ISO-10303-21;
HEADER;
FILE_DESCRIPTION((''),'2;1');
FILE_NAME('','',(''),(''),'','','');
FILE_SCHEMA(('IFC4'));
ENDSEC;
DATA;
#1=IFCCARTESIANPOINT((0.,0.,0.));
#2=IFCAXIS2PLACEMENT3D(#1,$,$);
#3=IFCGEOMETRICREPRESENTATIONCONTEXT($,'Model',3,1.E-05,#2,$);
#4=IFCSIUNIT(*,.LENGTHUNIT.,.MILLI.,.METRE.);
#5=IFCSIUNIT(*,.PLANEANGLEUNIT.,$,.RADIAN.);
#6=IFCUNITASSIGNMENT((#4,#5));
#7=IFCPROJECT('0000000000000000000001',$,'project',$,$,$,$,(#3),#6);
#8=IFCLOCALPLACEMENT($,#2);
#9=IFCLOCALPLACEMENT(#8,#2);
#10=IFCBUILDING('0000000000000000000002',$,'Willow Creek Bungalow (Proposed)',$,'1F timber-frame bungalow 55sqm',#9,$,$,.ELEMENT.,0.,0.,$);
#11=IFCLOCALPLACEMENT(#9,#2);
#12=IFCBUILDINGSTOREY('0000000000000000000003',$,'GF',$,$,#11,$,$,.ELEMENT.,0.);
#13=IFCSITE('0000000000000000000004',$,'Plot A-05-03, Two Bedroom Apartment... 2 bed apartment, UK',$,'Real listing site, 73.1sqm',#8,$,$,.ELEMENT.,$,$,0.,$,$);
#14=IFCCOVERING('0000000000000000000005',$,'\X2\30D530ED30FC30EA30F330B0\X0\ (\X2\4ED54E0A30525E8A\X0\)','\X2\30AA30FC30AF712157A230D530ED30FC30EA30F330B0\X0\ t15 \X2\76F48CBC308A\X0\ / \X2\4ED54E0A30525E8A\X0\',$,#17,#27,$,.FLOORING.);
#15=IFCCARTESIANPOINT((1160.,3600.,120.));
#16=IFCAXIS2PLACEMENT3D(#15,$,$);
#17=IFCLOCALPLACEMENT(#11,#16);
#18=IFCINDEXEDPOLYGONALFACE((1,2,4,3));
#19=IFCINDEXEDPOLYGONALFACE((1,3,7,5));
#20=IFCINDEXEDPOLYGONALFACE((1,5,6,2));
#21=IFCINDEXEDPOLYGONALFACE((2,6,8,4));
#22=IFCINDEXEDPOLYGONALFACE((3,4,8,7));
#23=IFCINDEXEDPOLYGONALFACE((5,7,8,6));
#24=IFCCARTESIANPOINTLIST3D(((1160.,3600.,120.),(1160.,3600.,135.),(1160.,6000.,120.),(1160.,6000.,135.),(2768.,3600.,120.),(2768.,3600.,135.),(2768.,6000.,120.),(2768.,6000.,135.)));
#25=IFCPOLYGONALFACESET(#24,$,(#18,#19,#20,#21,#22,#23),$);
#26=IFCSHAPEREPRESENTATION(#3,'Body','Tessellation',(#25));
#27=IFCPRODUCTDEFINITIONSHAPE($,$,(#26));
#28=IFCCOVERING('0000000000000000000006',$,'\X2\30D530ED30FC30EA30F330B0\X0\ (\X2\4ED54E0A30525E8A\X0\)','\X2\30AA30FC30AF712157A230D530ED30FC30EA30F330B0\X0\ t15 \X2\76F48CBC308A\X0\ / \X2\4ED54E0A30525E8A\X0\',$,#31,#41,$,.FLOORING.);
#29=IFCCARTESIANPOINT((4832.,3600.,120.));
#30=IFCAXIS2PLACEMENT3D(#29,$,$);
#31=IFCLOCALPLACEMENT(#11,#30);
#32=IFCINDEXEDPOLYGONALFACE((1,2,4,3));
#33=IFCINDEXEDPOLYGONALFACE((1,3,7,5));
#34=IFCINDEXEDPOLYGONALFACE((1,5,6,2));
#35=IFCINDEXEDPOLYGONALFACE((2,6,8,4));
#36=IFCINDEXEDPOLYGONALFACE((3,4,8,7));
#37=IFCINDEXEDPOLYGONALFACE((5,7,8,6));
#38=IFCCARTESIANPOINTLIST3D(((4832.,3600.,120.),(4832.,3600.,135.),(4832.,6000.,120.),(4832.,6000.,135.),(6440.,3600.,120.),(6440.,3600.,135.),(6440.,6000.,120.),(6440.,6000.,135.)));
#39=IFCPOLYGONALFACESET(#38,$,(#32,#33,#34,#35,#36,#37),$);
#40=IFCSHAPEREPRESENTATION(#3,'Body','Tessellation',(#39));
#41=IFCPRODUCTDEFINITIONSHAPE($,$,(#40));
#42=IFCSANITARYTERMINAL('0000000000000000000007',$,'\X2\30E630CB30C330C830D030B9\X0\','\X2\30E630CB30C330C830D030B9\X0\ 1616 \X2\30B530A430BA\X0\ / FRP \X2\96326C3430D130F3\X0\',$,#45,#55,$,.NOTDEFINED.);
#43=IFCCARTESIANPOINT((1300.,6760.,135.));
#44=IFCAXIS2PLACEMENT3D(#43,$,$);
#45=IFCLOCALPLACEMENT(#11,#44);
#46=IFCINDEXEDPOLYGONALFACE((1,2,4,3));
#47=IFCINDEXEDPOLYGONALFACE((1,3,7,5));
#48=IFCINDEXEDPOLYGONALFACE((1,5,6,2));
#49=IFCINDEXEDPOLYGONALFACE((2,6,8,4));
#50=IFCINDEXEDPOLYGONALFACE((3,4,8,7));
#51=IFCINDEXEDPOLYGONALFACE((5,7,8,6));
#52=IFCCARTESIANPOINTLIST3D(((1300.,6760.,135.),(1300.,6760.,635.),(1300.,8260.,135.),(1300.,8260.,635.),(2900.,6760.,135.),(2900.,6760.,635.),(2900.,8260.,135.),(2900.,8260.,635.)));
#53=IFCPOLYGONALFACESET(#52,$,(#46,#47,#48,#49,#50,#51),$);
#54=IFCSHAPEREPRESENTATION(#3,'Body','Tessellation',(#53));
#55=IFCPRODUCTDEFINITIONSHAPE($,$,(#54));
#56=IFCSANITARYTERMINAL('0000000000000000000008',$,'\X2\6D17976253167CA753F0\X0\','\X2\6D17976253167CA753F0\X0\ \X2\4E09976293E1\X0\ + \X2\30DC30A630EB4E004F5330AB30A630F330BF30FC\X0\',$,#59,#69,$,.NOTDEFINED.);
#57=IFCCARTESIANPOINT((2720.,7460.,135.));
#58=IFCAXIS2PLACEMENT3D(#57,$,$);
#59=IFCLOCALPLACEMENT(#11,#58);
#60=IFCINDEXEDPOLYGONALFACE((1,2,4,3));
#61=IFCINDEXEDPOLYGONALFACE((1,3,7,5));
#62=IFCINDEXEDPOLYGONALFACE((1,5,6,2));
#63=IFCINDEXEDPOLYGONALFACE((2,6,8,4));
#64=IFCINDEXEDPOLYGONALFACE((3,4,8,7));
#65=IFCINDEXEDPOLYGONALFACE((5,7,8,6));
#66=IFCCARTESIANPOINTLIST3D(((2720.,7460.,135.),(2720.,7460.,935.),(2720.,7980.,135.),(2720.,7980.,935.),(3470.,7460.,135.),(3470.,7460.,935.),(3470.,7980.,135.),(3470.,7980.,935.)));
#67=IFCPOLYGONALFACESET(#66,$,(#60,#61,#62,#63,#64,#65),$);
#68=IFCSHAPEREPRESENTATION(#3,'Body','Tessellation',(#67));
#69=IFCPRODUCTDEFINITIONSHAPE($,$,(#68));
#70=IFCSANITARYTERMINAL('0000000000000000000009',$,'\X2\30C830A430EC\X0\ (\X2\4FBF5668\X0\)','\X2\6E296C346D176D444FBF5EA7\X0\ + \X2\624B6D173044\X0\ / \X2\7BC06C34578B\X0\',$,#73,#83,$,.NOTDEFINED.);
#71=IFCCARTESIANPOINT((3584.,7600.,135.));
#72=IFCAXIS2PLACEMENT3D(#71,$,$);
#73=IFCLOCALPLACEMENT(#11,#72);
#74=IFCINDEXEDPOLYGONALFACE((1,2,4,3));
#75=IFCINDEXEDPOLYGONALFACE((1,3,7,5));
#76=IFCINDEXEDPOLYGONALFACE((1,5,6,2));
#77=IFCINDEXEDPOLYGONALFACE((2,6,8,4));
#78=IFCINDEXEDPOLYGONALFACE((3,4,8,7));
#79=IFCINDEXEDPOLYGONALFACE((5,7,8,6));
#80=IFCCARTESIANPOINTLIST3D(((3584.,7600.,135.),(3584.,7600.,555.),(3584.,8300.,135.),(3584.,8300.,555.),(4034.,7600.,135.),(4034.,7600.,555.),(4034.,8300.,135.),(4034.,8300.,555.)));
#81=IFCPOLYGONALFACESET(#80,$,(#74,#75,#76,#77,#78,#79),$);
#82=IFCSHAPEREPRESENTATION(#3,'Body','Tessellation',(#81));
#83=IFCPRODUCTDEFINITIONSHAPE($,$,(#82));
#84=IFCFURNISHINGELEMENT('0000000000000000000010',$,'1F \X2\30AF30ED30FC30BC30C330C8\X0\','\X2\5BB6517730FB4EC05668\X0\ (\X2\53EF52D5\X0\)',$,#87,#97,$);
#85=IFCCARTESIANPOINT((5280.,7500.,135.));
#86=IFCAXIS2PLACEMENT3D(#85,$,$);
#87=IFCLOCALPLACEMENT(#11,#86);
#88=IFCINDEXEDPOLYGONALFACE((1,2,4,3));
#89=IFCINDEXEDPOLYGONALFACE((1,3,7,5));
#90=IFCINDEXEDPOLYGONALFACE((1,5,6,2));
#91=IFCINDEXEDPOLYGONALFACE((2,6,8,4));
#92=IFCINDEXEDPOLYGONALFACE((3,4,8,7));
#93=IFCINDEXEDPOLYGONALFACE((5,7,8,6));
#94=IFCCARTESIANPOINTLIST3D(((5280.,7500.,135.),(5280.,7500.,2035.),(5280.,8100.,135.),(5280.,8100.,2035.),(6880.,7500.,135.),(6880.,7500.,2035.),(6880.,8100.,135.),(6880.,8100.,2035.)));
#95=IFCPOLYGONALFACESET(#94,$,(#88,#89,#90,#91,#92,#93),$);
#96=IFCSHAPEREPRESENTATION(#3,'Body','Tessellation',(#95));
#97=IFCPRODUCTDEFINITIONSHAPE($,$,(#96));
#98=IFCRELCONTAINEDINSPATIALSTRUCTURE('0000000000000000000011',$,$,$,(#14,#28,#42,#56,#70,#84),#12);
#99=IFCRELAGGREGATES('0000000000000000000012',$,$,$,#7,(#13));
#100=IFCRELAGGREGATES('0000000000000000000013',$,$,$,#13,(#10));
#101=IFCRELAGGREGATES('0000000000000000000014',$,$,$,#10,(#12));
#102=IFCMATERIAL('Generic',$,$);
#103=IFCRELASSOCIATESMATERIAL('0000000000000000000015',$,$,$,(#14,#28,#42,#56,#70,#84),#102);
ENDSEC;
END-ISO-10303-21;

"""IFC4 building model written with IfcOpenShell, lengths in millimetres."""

from ifc_helpers import new_model, si_unit, frame, frame_2d, origin, place, context, project, spatial, rectangle, extrude, material, element, save


model = new_model("IFC4")

# Units and contexts
model_context = context("Model", 3, precision=1e-05, world=origin())
ifc_project = project(units=[si_unit("LENGTHUNIT", "METRE", prefix="MILLI"), si_unit("PLANEANGLEUNIT", "RADIAN")], contexts=[model_context])

# Site, building, storey
site_placement = place(None, origin())
site = spatial("IfcSite", under=ifc_project, at=site_placement, Name="Plot A-05-03, Two Bedroom Apartment... 2 bed apartment, UK", ObjectType="Real listing site, 73.1sqm", CompositionType="ELEMENT", RefElevation=0.0)
building_placement = place(site_placement, origin())
building = spatial("IfcBuilding", under=site, at=building_placement, Name="Willow Creek Bungalow (Proposed)", ObjectType="1F timber-frame bungalow 55sqm", CompositionType="ELEMENT", ElevationOfRefHeight=0.0, ElevationOfTerrain=0.0)
storey_placement = place(building_placement, origin())
storey = spatial("IfcBuildingStorey", under=building, at=storey_placement, Name="GF", CompositionType="ELEMENT", Elevation=0.0)

# Coverings
ifc_material_1 = material(Name="Generic")
covering_1_placement = place(storey_placement, frame((1160.0, 3600.0, 120.0)))
element("IfcCovering", 1, at=covering_1_placement, inside=storey, material=ifc_material_1, Name="フローリング (仕上げ床)", Description="オーク無垢フローリング t15 直貼り / 仕上げ床", PredefinedType="FLOORING", context=model_context, shape_type="SweptSolid", body=[
    extrude(rectangle(XDim=1608.0, YDim=2400.0, at=frame_2d((804.0, 1200.0))), frame((1160.0, 3600.0, 120.0)), (0.0, 0.0, 1.0), 15.0),
])
covering_2_placement = place(storey_placement, frame((4832.0, 3600.0, 120.0)))
element("IfcCovering", 2, at=covering_2_placement, inside=storey, material=ifc_material_1, Name="フローリング (仕上げ床)", Description="オーク無垢フローリング t15 直貼り / 仕上げ床", PredefinedType="FLOORING", context=model_context, shape_type="SweptSolid", body=[
    extrude(rectangle(XDim=1608.0, YDim=2400.0, at=frame_2d((804.0, 1200.0))), frame((4832.0, 3600.0, 120.0)), (0.0, 0.0, 1.0), 15.0),
])

# Sanitary terminals
sanitary_terminal_1_placement = place(storey_placement, frame((1300.0, 6760.0, 135.0)))
element("IfcSanitaryTerminal", 3, at=sanitary_terminal_1_placement, inside=storey, material=ifc_material_1, Name="ユニットバス", Description="ユニットバス 1616 サイズ / FRP 防水パン", PredefinedType="NOTDEFINED", context=model_context, shape_type="SweptSolid", body=[
    extrude(rectangle(XDim=1600.0, YDim=1500.0, at=frame_2d((800.0, 750.0))), frame((1300.0, 6760.0, 135.0)), (0.0, 0.0, 1.0), 500.0),
])
sanitary_terminal_2_placement = place(storey_placement, frame((2720.0, 7460.0, 135.0)))
element("IfcSanitaryTerminal", 4, at=sanitary_terminal_2_placement, inside=storey, material=ifc_material_1, Name="洗面化粧台", Description="洗面化粧台 三面鏡 + ボウル一体カウンター", PredefinedType="NOTDEFINED", context=model_context, shape_type="SweptSolid", body=[
    extrude(rectangle(XDim=750.0, YDim=520.0, at=frame_2d((375.0, 260.0))), frame((2720.0, 7460.0, 135.0)), (0.0, 0.0, 1.0), 800.0),
])
sanitary_terminal_3_placement = place(storey_placement, frame((3584.0, 7600.0, 135.0)))
element("IfcSanitaryTerminal", 5, at=sanitary_terminal_3_placement, inside=storey, material=ifc_material_1, Name="トイレ (便器)", Description="温水洗浄便座 + 手洗い / 節水型", PredefinedType="NOTDEFINED", context=model_context, shape_type="SweptSolid", body=[
    extrude(rectangle(XDim=450.0, YDim=700.0, at=frame_2d((225.0, 350.0))), frame((3584.0, 7600.0, 135.0)), (0.0, 0.0, 1.0), 420.0),
])

# Furnishing element
furnishing_placement = place(storey_placement, frame((5280.0, 7500.0, 135.0)))
element("IfcFurnishingElement", 6, at=furnishing_placement, inside=storey, material=ifc_material_1, Name="1F クローゼット", Description="家具・什器 (可動)", context=model_context, shape_type="SweptSolid", body=[
    extrude(rectangle(XDim=1600.0, YDim=600.0, at=frame_2d((800.0, 300.0))), frame((5280.0, 7500.0, 135.0)), (0.0, 0.0, 1.0), 1900.0),
])

save(model, "model.ifc")
